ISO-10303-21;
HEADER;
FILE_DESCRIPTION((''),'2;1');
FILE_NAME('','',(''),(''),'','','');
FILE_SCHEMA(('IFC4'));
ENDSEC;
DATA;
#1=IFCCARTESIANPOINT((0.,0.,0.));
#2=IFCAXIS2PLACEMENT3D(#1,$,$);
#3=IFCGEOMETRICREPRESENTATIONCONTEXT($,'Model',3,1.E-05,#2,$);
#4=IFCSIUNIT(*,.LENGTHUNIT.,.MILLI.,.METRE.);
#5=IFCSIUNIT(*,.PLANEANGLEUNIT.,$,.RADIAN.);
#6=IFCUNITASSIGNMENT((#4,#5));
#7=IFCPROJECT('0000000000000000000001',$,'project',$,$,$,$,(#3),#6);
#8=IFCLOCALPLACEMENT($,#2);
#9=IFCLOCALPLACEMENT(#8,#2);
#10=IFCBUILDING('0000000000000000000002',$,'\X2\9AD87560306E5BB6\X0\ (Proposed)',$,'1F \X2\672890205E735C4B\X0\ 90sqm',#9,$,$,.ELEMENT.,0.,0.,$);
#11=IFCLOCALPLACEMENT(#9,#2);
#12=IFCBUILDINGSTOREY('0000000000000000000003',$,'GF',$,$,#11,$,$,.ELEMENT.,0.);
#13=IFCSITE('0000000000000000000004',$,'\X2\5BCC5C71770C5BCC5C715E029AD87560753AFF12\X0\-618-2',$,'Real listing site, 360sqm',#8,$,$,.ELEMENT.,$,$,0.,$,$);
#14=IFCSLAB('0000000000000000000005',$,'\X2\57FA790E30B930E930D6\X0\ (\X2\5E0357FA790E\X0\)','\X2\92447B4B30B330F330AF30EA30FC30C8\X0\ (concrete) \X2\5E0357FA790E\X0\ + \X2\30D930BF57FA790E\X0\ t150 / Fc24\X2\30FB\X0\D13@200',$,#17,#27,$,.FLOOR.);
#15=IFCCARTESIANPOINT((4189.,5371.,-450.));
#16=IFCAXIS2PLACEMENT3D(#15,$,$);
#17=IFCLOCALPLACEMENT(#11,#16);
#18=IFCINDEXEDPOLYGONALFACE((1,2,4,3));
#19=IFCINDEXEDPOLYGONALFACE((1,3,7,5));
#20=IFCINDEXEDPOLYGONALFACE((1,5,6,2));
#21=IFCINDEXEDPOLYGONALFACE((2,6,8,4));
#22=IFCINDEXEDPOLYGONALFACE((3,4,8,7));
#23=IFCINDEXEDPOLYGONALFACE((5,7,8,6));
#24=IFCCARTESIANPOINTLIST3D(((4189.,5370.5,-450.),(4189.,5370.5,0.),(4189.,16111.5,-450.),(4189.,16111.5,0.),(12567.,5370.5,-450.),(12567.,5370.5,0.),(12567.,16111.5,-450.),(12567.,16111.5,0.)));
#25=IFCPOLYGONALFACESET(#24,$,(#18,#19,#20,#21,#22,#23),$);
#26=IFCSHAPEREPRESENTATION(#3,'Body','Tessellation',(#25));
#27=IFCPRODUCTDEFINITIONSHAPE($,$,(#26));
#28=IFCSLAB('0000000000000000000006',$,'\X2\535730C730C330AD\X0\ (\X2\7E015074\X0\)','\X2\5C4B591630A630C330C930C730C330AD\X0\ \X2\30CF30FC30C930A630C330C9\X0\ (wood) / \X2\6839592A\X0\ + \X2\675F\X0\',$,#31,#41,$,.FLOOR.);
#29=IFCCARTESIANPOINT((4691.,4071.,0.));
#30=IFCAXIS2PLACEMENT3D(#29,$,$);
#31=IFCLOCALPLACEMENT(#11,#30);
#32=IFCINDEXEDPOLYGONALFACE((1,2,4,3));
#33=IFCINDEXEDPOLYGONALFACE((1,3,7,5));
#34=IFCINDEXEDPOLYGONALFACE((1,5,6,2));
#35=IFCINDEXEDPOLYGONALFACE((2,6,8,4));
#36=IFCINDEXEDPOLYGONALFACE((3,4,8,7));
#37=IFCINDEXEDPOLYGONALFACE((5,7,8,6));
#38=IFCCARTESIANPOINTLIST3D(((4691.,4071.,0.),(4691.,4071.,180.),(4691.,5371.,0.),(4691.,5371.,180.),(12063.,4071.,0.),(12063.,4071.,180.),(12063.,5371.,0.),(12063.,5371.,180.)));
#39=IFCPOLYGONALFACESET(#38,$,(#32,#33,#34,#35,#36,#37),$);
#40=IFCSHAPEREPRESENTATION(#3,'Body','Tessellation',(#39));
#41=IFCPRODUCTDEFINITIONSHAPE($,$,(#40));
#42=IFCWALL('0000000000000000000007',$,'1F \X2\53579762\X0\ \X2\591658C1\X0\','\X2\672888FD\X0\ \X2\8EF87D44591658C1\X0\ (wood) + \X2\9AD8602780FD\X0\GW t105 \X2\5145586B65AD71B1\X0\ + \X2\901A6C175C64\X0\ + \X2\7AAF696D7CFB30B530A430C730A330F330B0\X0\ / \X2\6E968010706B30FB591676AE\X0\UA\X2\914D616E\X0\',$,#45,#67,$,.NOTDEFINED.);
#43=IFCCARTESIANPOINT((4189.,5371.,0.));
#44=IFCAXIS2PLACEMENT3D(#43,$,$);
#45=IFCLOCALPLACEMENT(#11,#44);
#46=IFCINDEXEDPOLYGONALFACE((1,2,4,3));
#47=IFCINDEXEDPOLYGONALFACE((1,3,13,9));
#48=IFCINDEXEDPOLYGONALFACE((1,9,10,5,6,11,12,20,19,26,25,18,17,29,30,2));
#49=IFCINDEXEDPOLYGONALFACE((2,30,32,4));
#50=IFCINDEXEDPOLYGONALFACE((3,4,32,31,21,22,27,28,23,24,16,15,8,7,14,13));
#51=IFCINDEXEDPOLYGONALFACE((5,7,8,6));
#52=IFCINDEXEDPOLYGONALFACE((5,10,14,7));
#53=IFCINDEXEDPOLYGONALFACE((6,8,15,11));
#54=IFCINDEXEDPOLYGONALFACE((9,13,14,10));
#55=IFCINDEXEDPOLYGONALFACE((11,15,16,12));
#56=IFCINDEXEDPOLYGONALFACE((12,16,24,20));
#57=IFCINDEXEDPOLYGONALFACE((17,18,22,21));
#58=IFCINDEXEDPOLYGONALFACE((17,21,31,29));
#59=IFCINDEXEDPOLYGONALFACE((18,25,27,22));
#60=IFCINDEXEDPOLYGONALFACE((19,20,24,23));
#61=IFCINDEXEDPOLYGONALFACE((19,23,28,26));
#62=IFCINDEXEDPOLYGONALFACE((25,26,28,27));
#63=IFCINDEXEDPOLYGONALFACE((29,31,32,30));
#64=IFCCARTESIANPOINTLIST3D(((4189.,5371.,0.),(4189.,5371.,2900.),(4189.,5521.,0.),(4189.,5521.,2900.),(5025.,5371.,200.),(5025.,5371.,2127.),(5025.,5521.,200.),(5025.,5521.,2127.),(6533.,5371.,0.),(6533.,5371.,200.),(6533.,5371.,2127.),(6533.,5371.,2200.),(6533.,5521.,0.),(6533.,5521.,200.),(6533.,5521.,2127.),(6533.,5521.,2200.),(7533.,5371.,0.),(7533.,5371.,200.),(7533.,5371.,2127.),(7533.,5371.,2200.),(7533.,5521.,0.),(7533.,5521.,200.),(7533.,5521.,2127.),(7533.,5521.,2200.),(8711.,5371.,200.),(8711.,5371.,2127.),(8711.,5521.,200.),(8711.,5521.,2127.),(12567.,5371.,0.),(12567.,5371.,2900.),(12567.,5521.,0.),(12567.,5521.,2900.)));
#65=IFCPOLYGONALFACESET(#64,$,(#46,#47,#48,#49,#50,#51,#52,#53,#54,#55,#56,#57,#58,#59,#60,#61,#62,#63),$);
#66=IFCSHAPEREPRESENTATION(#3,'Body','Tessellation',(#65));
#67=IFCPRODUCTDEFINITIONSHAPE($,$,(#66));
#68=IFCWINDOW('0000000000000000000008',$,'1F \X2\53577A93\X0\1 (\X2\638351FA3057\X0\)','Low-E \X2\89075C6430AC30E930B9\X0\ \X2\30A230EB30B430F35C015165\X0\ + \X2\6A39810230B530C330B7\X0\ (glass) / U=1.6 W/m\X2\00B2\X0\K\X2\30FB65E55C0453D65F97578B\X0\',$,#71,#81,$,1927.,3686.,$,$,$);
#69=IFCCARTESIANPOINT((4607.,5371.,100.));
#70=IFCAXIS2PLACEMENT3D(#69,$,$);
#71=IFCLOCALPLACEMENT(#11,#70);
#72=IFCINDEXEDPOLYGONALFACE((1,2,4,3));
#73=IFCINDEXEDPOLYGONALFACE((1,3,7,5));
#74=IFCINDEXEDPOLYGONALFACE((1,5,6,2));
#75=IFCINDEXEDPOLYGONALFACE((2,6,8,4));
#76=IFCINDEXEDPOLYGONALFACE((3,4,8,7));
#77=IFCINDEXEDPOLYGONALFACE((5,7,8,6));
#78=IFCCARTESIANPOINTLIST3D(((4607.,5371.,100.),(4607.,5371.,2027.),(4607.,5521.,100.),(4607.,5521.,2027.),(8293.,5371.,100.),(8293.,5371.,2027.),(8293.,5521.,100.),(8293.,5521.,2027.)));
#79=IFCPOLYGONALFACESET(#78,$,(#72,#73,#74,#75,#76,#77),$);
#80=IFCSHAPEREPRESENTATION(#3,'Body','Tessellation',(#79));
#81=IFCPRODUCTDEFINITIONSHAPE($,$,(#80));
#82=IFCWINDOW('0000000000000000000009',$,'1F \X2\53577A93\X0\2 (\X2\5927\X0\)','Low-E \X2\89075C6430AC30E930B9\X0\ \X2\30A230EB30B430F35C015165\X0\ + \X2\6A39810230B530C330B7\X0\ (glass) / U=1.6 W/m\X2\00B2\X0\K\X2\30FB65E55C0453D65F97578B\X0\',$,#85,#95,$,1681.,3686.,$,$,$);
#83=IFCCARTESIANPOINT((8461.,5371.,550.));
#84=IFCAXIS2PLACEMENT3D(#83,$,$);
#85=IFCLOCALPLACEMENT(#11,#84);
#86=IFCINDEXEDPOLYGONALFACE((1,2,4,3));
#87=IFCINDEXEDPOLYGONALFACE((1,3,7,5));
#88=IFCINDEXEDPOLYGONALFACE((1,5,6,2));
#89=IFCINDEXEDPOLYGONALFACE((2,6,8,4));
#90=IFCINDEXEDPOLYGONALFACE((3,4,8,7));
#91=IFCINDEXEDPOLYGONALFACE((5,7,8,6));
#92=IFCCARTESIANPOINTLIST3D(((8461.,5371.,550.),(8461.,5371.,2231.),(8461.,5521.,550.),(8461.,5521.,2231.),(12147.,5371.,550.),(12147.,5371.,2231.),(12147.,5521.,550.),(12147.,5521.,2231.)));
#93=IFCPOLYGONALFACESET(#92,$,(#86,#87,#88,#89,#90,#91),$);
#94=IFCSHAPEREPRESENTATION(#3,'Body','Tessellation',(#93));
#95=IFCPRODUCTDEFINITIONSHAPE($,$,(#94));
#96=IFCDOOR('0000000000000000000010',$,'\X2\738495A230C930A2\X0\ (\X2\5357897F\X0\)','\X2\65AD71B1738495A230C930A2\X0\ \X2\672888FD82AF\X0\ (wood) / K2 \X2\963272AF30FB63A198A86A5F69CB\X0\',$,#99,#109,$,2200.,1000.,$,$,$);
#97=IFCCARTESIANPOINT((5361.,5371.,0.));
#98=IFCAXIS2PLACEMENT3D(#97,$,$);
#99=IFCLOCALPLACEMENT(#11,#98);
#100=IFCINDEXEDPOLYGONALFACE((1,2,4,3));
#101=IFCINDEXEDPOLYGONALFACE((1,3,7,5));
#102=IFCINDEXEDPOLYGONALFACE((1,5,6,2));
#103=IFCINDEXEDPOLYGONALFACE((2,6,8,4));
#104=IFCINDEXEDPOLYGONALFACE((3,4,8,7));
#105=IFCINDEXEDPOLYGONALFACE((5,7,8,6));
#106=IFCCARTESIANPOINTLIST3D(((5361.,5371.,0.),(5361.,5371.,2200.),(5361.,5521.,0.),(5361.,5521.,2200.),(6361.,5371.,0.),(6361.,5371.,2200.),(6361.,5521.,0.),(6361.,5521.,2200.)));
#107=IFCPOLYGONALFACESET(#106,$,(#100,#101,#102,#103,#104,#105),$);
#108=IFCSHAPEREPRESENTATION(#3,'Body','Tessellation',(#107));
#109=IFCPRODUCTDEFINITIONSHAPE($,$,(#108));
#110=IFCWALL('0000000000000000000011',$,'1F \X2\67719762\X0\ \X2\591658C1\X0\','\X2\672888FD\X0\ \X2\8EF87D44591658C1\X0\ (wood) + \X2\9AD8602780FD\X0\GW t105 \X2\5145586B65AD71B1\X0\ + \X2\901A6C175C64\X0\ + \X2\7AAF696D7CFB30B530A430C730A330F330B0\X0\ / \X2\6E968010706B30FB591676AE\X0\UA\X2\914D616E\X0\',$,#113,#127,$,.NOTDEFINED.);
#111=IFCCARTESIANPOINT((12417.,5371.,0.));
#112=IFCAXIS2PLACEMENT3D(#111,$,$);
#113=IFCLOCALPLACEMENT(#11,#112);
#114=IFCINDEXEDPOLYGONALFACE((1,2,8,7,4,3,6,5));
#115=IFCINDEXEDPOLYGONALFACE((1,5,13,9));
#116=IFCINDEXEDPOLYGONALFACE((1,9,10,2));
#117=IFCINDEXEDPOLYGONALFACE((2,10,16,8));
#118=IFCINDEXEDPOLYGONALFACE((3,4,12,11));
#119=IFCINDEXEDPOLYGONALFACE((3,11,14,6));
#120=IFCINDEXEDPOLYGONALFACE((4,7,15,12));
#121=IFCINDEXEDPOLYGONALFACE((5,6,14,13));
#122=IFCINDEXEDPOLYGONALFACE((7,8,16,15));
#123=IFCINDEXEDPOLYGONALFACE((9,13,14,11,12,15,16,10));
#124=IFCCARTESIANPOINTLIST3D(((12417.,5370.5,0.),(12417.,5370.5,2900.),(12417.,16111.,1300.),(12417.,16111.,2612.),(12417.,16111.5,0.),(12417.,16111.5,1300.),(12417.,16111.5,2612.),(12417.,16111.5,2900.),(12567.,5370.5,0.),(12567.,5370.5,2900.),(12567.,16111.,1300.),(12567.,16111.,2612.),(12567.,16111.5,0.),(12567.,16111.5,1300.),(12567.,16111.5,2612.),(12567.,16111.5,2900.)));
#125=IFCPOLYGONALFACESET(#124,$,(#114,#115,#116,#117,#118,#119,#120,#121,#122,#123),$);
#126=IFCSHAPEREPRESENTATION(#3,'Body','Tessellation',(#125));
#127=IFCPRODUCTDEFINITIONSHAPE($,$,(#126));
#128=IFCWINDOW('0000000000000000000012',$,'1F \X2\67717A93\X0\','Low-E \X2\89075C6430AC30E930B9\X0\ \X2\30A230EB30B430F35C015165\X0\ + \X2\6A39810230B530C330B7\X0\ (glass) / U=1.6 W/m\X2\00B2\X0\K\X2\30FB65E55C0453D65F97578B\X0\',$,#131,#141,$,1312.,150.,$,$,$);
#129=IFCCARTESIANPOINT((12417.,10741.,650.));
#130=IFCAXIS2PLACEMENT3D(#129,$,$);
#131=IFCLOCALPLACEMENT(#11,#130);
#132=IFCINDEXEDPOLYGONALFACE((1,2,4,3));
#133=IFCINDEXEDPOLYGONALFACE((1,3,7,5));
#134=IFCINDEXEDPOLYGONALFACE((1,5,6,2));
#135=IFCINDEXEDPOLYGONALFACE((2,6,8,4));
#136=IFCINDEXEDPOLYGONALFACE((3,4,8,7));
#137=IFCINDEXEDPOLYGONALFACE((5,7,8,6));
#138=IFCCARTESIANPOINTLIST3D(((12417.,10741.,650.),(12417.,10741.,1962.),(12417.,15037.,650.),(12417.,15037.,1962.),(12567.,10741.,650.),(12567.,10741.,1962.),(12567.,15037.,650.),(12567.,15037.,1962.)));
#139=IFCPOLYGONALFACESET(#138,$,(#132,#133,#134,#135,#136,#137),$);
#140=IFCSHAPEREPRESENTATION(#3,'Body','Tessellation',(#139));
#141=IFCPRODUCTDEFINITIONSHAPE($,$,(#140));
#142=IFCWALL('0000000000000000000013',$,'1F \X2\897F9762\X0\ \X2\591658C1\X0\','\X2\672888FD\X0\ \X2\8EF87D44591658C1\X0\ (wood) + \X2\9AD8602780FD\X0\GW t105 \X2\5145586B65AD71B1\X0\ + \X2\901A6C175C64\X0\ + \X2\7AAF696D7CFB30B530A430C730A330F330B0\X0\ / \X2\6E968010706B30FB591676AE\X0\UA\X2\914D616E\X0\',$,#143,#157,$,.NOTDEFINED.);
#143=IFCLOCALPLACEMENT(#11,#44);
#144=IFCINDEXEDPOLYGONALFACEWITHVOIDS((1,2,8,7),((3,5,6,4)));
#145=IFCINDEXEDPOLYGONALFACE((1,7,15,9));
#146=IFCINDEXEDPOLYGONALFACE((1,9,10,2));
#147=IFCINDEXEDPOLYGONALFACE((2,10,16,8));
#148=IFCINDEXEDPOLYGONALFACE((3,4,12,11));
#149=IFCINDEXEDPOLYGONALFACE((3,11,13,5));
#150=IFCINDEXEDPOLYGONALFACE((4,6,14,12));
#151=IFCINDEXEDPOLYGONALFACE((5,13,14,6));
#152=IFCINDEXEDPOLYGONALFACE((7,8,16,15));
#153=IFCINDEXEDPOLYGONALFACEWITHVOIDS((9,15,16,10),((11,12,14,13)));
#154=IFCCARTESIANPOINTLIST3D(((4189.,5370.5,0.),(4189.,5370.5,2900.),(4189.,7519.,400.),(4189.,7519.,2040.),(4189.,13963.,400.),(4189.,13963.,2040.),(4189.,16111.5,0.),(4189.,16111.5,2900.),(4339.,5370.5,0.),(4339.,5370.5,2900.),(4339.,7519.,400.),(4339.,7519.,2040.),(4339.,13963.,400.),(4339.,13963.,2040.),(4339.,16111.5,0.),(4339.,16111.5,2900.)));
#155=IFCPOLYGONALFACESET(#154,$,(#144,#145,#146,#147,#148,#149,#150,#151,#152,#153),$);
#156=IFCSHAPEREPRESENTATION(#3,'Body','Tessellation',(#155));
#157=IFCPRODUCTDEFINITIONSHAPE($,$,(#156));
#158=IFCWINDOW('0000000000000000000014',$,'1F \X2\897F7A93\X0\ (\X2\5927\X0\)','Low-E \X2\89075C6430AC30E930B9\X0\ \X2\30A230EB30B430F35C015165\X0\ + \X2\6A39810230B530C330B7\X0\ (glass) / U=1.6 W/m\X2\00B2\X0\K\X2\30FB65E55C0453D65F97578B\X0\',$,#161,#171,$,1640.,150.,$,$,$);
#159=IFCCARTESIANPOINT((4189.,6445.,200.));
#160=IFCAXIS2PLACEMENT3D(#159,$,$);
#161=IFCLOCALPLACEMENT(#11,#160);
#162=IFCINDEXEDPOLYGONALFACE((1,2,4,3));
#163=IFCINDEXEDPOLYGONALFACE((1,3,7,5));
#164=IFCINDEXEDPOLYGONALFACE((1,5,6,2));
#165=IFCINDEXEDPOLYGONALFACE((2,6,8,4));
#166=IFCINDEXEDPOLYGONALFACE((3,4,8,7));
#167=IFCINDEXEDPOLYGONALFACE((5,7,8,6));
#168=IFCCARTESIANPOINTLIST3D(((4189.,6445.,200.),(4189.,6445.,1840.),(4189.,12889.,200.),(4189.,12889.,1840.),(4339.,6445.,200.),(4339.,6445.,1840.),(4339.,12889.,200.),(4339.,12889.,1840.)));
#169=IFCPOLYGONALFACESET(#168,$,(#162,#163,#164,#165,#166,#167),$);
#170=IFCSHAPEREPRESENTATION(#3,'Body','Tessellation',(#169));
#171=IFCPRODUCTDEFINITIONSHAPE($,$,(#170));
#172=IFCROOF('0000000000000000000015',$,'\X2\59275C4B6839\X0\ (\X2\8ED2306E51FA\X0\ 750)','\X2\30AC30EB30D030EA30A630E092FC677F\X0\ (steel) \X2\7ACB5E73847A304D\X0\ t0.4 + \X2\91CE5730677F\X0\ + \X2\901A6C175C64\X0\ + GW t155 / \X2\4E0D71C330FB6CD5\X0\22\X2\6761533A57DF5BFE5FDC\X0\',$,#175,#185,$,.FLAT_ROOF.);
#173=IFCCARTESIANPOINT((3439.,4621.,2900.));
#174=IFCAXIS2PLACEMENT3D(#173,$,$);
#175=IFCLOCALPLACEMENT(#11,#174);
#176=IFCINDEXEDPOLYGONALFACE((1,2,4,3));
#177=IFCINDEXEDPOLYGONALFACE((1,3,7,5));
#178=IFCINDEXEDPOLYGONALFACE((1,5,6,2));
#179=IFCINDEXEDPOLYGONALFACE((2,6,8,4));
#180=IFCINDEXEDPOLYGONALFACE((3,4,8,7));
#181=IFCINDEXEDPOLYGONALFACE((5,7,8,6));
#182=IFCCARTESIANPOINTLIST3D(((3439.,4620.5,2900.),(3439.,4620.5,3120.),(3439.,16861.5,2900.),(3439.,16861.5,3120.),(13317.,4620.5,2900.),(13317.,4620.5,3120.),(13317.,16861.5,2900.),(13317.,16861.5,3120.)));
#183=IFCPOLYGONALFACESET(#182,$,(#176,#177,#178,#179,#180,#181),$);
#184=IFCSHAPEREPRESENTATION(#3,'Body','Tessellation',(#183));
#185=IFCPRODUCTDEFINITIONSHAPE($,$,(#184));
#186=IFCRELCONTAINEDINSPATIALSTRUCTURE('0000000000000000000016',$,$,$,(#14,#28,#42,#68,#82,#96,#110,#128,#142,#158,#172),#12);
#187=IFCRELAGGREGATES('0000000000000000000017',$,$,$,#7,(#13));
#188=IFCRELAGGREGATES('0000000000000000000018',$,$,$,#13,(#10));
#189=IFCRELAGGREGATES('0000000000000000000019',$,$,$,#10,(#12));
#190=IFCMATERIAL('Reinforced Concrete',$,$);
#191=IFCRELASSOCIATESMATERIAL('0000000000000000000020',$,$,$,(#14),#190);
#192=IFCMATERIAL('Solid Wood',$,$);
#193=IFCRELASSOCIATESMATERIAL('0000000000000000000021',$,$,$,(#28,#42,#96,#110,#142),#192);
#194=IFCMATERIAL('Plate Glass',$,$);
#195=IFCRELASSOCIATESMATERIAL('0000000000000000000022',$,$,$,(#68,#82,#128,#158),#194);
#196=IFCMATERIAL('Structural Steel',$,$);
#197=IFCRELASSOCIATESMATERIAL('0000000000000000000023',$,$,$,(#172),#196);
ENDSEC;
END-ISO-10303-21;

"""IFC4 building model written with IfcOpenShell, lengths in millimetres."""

from ifc_helpers import new_model, si_unit, frame, frame_2d, origin, place, context, project, spatial, rectangle, extrude, material, element, fill, save


model = new_model("IFC4")

# Units and contexts
model_context = context("Model", 3, precision=1e-05, world=origin())
ifc_project = project(units=[si_unit("LENGTHUNIT", "METRE", prefix="MILLI"), si_unit("PLANEANGLEUNIT", "RADIAN")], contexts=[model_context])

# Site, building, storey
site_placement = place(None, origin())
site = spatial("IfcSite", under=ifc_project, at=site_placement, Name="富山県富山市高畠町２-618-2", ObjectType="Real listing site, 360sqm", CompositionType="ELEMENT", RefElevation=0.0)
building_placement = place(site_placement, origin())
building = spatial("IfcBuilding", under=site, at=building_placement, Name="高畠の家 (Proposed)", ObjectType="1F 木造平屋 90sqm", CompositionType="ELEMENT", ElevationOfRefHeight=0.0, ElevationOfTerrain=0.0)
storey_placement = place(building_placement, origin())
storey = spatial("IfcBuildingStorey", under=building, at=storey_placement, Name="GF", CompositionType="ELEMENT", Elevation=0.0)

# Slabs
ifc_material_1 = material(Name="Reinforced Concrete")
slab_1_placement = place(storey_placement, frame((4189.0, 5371.0, -450.0)))
element("IfcSlab", 1, at=slab_1_placement, inside=storey, material=ifc_material_1, Name="基礎スラブ (布基礎)", Description="鉄筋コンクリート (concrete) 布基礎 + ベタ基礎 t150 / Fc24・D13@200", PredefinedType="FLOOR", context=model_context, shape_type="SweptSolid", body=[
    extrude(rectangle(XDim=8378.0, YDim=10741.0, at=frame_2d((4189.0, 5370.0))), frame((4189.0, 5371.0, -450.0)), (0.0, 0.0, 1.0), 450.0),
])
ifc_material_2 = material(Name="Solid Wood")
slab_2_placement = place(storey_placement, frame((4691.0, 4071.0, 0.0)))
element("IfcSlab", 2, at=slab_2_placement, inside=storey, material=ifc_material_2, Name="南デッキ (縁側)", Description="屋外ウッドデッキ ハードウッド (wood) / 根太 + 束", PredefinedType="FLOOR", context=model_context, shape_type="SweptSolid", body=[
    extrude(rectangle(XDim=7372.0, YDim=1300.0, at=frame_2d((3686.0, 650.0))), frame((4691.0, 4071.0, 0.0)), (0.0, 0.0, 1.0), 180.0),
])

# Wall, openings, windows, door
wall_1_placement = place(storey_placement, frame((4189.0, 5371.0, 0.0)))
wall_1 = element("IfcWall", 3, at=wall_1_placement, inside=storey, material=ifc_material_2, Name="1F 南面 外壁", Description="木製 軸組外壁 (wood) + 高性能GW t105 充填断熱 + 通気層 + 窯業系サイディング / 準耐火・外皮UA配慮", PredefinedType="NOTDEFINED", context=model_context, shape_type="SweptSolid", body=[
    extrude(rectangle(XDim=8378.0, YDim=150.0, at=frame_2d((4189.0, 75.0))), frame((4189.0, 5371.0, 0.0)), (0.0, 0.0, 1.0), 2900.0),
])
opening_1_placement = place(storey_placement, frame((4607.0, 5371.0, 100.0)))
opening_1 = element("IfcOpeningElement", 4, at=opening_1_placement, cuts=wall_1, PredefinedType="NOTDEFINED", context=model_context, shape_type="SweptSolid", body=[
    extrude(rectangle(XDim=3686.0, YDim=150.0, at=frame_2d((1843.0, 75.0))), frame((4607.0, 5371.0, 100.0)), (0.0, 0.0, 1.0), 1927.0),
])
opening_2_placement = place(storey_placement, frame((8461.0, 5371.0, 550.0)))
opening_2 = element("IfcOpeningElement", 5, at=opening_2_placement, cuts=wall_1, PredefinedType="NOTDEFINED", context=model_context, shape_type="SweptSolid", body=[
    extrude(rectangle(XDim=3686.0, YDim=150.0, at=frame_2d((1843.0, 75.0))), frame((8461.0, 5371.0, 550.0)), (0.0, 0.0, 1.0), 1681.0),
])
opening_3_placement = place(storey_placement, frame((5361.0, 5371.0, 0.0)))
opening_3 = element("IfcOpeningElement", 6, at=opening_3_placement, cuts=wall_1, PredefinedType="NOTDEFINED", context=model_context, shape_type="SweptSolid", body=[
    extrude(rectangle(XDim=1000.0, YDim=150.0, at=frame_2d((500.0, 75.0))), frame((5361.0, 5371.0, 0.0)), (0.0, 0.0, 1.0), 2200.0),
])
ifc_material_3 = material(Name="Plate Glass")
window_1_placement = place(storey_placement, frame((4607.0, 5371.0, 100.0)))
window_1 = element("IfcWindow", 7, at=window_1_placement, inside=storey, material=ifc_material_3, Name="1F 南窓1 (掃出し)", Description="Low-E 複層ガラス アルゴン封入 + 樹脂サッシ (glass) / U=1.6 W/m²K・日射取得型", OverallHeight=1927.0, OverallWidth=3686.0, context=model_context, shape_type="SweptSolid", body=[
    extrude(rectangle(XDim=3686.0, YDim=150.0, at=frame_2d((1843.0, 75.0))), frame((4607.0, 5371.0, 100.0)), (0.0, 0.0, 1.0), 1927.0),
])
fill(opening_1, window_1)
window_2_placement = place(storey_placement, frame((8461.0, 5371.0, 550.0)))
window_2 = element("IfcWindow", 8, at=window_2_placement, inside=storey, material=ifc_material_3, Name="1F 南窓2 (大)", Description="Low-E 複層ガラス アルゴン封入 + 樹脂サッシ (glass) / U=1.6 W/m²K・日射取得型", OverallHeight=1681.0, OverallWidth=3686.0, context=model_context, shape_type="SweptSolid", body=[
    extrude(rectangle(XDim=3686.0, YDim=150.0, at=frame_2d((1843.0, 75.0))), frame((8461.0, 5371.0, 550.0)), (0.0, 0.0, 1.0), 1681.0),
])
fill(opening_2, window_2)
door_placement = place(storey_placement, frame((5361.0, 5371.0, 0.0)))
door = element("IfcDoor", 9, at=door_placement, inside=storey, material=ifc_material_2, Name="玄関ドア (南西)", Description="断熱玄関ドア 木製芯 (wood) / K2 防犯・採風機構", OverallHeight=2200.0, OverallWidth=1000.0, context=model_context, shape_type="SweptSolid", body=[
    extrude(rectangle(XDim=1000.0, YDim=150.0, at=frame_2d((500.0, 75.0))), frame((5361.0, 5371.0, 0.0)), (0.0, 0.0, 1.0), 2200.0),
])
fill(opening_3, door)

# Walls, openings, windows
wall_2_placement = place(storey_placement, frame((12417.0, 5371.0, 0.0)))
wall_2 = element("IfcWall", 10, at=wall_2_placement, inside=storey, material=ifc_material_2, Name="1F 東面 外壁", Description="木製 軸組外壁 (wood) + 高性能GW t105 充填断熱 + 通気層 + 窯業系サイディング / 準耐火・外皮UA配慮", PredefinedType="NOTDEFINED", context=model_context, shape_type="SweptSolid", body=[
    extrude(rectangle(XDim=150.0, YDim=10741.0, at=frame_2d((75.0, 5370.0))), frame((12417.0, 5371.0, 0.0)), (0.0, 0.0, 1.0), 2900.0),
])
opening_4_placement = place(storey_placement, frame((12417.0, 10741.0, 650.0)))
opening_4 = element("IfcOpeningElement", 11, at=opening_4_placement, cuts=wall_2, PredefinedType="NOTDEFINED", context=model_context, shape_type="SweptSolid", body=[
    extrude(rectangle(XDim=150.0, YDim=4296.0, at=frame_2d((75.0, 2148.0))), frame((12417.0, 10741.0, 650.0)), (0.0, 0.0, 1.0), 1312.0),
])
window_3_placement = place(storey_placement, frame((12417.0, 10741.0, 650.0)))
window_3 = element("IfcWindow", 12, at=window_3_placement, inside=storey, material=ifc_material_3, Name="1F 東窓", Description="Low-E 複層ガラス アルゴン封入 + 樹脂サッシ (glass) / U=1.6 W/m²K・日射取得型", OverallHeight=1312.0, OverallWidth=150.0, context=model_context, shape_type="SweptSolid", body=[
    extrude(rectangle(XDim=150.0, YDim=4296.0, at=frame_2d((75.0, 2148.0))), frame((12417.0, 10741.0, 650.0)), (0.0, 0.0, 1.0), 1312.0),
])
fill(opening_4, window_3)
wall_3_placement = place(storey_placement, frame((4189.0, 5371.0, 0.0)))
wall_3 = element("IfcWall", 13, at=wall_3_placement, inside=storey, material=ifc_material_2, Name="1F 西面 外壁", Description="木製 軸組外壁 (wood) + 高性能GW t105 充填断熱 + 通気層 + 窯業系サイディング / 準耐火・外皮UA配慮", PredefinedType="NOTDEFINED", context=model_context, shape_type="SweptSolid", body=[
    extrude(rectangle(XDim=150.0, YDim=10741.0, at=frame_2d((75.0, 5370.0))), frame((4189.0, 5371.0, 0.0)), (0.0, 0.0, 1.0), 2900.0),
])
opening_5_placement = place(storey_placement, frame((4189.0, 6445.0, 200.0)))
opening_5 = element("IfcOpeningElement", 14, at=opening_5_placement, cuts=wall_3, PredefinedType="NOTDEFINED", context=model_context, shape_type="SweptSolid", body=[
    extrude(rectangle(XDim=150.0, YDim=6444.0, at=frame_2d((75.0, 3222.0))), frame((4189.0, 6445.0, 200.0)), (0.0, 0.0, 1.0), 1640.0),
])
window_4_placement = place(storey_placement, frame((4189.0, 6445.0, 200.0)))
window_4 = element("IfcWindow", 15, at=window_4_placement, inside=storey, material=ifc_material_3, Name="1F 西窓 (大)", Description="Low-E 複層ガラス アルゴン封入 + 樹脂サッシ (glass) / U=1.6 W/m²K・日射取得型", OverallHeight=1640.0, OverallWidth=150.0, context=model_context, shape_type="SweptSolid", body=[
    extrude(rectangle(XDim=150.0, YDim=6444.0, at=frame_2d((75.0, 3222.0))), frame((4189.0, 6445.0, 200.0)), (0.0, 0.0, 1.0), 1640.0),
])
fill(opening_5, window_4)

# Roof
ifc_material_4 = material(Name="Structural Steel")
roof_placement = place(storey_placement, frame((3439.0, 4621.0, 2900.0)))
element("IfcRoof", 16, at=roof_placement, inside=storey, material=ifc_material_4, Name="大屋根 (軒の出 750)", Description="ガルバリウム鋼板 (steel) 立平葺き t0.4 + 野地板 + 通気層 + GW t155 / 不燃・法22条区域対応", PredefinedType="FLAT_ROOF", context=model_context, shape_type="SweptSolid", body=[
    extrude(rectangle(XDim=9878.0, YDim=12241.0, at=frame_2d((4939.0, 6120.0))), frame((3439.0, 4621.0, 2900.0)), (0.0, 0.0, 1.0), 220.0),
])

save(model, "model.ifc")
